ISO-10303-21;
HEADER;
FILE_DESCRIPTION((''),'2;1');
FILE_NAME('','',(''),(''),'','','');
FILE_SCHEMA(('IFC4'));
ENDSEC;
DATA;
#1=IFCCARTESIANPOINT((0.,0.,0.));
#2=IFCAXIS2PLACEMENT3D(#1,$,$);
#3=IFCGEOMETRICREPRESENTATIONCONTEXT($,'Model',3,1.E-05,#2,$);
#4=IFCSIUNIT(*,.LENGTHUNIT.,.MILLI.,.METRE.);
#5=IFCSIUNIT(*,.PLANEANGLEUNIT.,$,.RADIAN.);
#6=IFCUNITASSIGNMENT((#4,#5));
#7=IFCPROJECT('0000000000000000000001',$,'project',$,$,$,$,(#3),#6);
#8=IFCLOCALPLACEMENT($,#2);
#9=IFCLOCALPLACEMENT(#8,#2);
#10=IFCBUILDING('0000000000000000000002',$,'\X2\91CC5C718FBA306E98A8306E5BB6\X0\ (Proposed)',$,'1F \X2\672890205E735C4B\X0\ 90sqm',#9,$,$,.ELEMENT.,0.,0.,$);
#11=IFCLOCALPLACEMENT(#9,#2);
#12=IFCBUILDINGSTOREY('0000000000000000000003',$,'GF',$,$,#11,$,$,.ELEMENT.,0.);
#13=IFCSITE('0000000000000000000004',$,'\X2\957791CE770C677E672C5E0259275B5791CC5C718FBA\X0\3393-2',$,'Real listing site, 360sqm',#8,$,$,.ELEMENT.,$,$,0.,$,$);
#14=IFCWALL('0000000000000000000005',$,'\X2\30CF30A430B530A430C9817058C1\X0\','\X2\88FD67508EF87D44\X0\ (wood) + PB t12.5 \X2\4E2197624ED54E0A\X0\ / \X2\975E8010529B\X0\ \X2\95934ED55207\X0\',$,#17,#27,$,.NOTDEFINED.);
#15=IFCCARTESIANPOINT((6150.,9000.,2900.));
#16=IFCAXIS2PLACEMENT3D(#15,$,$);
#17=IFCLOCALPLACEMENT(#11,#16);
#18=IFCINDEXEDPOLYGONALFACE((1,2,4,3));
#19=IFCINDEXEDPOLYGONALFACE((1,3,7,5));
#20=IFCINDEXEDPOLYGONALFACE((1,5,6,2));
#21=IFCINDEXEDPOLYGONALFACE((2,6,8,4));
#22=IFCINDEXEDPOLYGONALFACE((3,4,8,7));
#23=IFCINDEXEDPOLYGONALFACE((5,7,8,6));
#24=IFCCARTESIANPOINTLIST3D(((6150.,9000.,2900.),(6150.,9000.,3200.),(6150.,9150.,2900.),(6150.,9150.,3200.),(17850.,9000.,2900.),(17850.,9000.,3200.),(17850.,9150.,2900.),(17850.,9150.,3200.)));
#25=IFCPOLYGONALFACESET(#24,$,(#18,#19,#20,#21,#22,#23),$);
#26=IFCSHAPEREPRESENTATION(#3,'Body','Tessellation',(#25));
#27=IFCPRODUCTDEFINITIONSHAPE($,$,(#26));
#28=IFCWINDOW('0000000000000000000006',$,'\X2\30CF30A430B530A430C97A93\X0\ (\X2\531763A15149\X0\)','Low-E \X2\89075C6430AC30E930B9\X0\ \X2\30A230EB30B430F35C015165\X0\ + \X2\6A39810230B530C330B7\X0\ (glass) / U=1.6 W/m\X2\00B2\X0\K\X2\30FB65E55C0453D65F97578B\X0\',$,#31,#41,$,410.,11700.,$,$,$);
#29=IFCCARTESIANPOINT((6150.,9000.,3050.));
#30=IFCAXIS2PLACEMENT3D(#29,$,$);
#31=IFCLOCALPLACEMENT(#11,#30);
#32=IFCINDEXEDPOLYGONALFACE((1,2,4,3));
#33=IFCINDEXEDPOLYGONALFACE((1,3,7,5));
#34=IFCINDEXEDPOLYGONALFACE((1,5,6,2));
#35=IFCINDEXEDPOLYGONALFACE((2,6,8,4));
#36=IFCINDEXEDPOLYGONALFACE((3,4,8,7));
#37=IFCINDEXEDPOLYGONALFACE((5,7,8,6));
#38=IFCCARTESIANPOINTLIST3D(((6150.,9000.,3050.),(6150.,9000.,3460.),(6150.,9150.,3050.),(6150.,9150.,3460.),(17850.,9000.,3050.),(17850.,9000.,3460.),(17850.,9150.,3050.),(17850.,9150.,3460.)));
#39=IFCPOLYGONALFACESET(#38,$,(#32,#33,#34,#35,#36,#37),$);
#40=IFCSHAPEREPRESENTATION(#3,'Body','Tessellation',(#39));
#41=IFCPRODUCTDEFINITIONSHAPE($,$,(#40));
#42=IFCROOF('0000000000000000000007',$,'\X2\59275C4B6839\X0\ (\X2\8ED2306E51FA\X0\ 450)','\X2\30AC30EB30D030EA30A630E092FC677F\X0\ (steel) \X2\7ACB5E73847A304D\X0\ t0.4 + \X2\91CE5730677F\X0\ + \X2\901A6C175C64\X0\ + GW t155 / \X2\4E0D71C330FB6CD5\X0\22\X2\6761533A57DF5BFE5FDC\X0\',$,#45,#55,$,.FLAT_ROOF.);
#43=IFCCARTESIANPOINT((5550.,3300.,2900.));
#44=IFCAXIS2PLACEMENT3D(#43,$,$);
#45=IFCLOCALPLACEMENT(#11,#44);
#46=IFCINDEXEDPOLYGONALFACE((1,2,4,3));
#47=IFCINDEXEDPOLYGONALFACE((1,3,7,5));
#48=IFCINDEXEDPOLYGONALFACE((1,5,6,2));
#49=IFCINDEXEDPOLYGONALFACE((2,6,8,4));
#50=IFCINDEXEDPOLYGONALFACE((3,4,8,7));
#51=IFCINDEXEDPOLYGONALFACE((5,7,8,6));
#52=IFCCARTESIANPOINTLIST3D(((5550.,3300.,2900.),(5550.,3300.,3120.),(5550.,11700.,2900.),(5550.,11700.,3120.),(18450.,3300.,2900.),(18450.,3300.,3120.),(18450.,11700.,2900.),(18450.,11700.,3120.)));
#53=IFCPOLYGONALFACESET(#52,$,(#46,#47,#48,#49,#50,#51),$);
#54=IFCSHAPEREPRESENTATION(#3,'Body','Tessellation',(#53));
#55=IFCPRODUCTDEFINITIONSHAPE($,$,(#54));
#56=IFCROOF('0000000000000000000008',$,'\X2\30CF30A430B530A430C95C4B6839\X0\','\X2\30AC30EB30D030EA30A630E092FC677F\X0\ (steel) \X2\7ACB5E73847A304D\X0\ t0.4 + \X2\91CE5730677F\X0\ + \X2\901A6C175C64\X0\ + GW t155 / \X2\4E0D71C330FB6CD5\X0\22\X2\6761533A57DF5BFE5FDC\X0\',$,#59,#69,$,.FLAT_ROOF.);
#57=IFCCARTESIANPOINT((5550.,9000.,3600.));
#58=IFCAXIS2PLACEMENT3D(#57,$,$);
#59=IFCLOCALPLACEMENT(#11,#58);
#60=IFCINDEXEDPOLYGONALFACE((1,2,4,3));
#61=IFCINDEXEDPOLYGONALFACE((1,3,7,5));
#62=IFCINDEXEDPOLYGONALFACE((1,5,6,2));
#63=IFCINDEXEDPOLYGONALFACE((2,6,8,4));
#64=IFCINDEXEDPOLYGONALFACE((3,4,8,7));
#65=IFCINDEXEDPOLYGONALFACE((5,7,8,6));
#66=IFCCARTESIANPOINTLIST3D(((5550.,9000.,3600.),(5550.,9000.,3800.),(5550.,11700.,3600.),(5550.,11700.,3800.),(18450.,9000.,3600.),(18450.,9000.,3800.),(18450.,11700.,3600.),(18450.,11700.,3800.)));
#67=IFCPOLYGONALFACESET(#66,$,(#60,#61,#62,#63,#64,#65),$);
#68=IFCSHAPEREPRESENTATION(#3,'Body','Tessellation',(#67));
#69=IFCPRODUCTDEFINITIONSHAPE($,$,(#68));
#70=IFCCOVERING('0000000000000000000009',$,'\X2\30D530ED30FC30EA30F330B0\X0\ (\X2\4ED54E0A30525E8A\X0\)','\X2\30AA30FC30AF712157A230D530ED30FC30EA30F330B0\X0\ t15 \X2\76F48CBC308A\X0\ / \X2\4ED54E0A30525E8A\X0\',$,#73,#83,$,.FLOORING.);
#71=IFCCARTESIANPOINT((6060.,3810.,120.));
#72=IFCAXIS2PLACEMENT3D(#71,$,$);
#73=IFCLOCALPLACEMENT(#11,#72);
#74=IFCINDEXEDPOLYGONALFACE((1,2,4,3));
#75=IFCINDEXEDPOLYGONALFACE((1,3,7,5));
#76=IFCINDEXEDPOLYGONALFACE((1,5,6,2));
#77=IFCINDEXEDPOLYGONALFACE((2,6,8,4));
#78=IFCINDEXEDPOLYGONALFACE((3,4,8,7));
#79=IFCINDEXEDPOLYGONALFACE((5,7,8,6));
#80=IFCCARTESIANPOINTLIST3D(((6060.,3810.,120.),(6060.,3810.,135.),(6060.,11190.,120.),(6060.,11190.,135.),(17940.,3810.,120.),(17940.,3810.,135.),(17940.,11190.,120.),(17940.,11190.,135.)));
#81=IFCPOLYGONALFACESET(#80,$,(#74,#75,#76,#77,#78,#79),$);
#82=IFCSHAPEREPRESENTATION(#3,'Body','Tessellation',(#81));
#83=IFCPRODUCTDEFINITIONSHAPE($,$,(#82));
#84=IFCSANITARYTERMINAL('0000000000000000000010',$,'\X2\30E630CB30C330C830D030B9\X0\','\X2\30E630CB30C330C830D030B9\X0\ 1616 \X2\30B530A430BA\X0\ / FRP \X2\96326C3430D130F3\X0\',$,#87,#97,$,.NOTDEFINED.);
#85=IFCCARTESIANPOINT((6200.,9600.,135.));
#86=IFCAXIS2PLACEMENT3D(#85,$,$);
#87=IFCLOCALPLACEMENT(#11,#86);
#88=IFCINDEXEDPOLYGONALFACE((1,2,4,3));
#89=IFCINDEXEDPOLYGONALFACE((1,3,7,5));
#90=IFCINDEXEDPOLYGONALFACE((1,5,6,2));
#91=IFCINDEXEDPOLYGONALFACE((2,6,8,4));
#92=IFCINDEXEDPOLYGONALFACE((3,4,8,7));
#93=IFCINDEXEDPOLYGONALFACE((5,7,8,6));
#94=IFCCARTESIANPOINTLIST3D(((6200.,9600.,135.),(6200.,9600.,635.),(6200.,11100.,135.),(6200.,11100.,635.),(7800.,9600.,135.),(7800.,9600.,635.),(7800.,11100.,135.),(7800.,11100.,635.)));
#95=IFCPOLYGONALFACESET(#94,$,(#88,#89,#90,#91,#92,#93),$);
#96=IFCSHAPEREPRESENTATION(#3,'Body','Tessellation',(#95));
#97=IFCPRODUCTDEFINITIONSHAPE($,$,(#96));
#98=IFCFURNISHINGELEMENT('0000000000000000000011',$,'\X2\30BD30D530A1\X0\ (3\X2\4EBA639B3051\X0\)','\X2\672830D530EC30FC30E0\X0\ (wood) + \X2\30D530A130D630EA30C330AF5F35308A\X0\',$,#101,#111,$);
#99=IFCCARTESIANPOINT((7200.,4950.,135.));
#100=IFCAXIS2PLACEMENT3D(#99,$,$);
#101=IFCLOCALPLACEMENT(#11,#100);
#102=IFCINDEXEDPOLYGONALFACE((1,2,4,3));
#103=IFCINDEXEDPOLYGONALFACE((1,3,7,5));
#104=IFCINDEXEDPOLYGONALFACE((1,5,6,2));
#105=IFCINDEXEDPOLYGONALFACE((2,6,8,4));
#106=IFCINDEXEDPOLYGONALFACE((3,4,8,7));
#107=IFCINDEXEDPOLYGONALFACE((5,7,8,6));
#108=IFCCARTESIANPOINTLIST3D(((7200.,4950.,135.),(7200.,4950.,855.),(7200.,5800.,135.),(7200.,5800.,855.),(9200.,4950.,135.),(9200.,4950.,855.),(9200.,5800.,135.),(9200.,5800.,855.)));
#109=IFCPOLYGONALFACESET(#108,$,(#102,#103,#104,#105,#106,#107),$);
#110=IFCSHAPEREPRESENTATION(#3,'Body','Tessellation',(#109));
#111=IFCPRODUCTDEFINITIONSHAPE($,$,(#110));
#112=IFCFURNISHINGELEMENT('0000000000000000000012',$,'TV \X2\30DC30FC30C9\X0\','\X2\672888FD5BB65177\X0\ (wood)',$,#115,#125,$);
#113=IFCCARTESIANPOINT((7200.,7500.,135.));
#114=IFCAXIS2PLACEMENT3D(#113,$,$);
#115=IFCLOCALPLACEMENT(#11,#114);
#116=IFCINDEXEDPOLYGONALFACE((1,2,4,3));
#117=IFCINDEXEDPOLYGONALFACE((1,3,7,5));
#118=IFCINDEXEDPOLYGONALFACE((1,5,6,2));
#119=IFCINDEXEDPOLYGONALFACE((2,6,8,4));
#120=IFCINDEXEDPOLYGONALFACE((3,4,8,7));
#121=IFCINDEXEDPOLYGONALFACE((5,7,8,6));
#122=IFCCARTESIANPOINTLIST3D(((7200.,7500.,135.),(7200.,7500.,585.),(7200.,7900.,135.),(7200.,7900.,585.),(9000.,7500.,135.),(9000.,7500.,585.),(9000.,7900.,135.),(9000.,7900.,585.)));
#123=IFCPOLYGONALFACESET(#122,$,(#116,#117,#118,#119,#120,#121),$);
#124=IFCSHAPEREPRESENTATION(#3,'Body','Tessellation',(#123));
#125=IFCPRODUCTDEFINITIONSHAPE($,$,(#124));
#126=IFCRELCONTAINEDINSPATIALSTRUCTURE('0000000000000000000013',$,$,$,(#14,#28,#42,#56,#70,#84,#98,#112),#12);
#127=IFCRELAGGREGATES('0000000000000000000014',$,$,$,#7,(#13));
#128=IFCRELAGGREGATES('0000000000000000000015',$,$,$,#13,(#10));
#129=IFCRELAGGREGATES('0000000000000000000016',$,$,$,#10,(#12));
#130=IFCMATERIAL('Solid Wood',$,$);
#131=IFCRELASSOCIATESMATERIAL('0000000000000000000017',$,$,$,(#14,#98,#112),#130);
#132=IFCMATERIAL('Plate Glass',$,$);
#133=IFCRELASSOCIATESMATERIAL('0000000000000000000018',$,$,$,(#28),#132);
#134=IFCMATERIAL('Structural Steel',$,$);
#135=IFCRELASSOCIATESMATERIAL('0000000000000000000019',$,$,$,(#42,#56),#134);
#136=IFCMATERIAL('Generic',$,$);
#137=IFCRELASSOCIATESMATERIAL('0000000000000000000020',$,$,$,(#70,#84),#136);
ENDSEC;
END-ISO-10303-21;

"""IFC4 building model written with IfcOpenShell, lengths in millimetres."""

from ifc_helpers import new_model, si_unit, frame, frame_2d, origin, place, context, project, spatial, rectangle, extrude, material, element, fill, save


model = new_model("IFC4")

# Units and contexts
model_context = context("Model", 3, precision=1e-05, world=origin())
ifc_project = project(units=[si_unit("LENGTHUNIT", "METRE", prefix="MILLI"), si_unit("PLANEANGLEUNIT", "RADIAN")], contexts=[model_context])

# Site, building, storey
site_placement = place(None, origin())
site = spatial("IfcSite", under=ifc_project, at=site_placement, Name="長野県松本市大字里山辺3393-2", ObjectType="Real listing site, 360sqm", CompositionType="ELEMENT", RefElevation=0.0)
building_placement = place(site_placement, origin())
building = spatial("IfcBuilding", under=site, at=building_placement, Name="里山辺の風の家 (Proposed)", ObjectType="1F 木造平屋 90sqm", CompositionType="ELEMENT", ElevationOfRefHeight=0.0, ElevationOfTerrain=0.0)
storey_placement = place(building_placement, origin())
storey = spatial("IfcBuildingStorey", under=building, at=storey_placement, Name="GF", CompositionType="ELEMENT", Elevation=0.0)

# Shared definitions
ifc_material_1 = material(Name="Solid Wood")

# Shared definitions
ifc_material_2 = material(Name="Plate Glass")

# Wall, opening, window
wall_1_placement = place(storey_placement, frame((6150.0, 9000.0, 2900.0)))
wall_1 = element("IfcWall", 1, at=wall_1_placement, inside=storey, material=ifc_material_1, Name="ハイサイド腰壁", Description="製材軸組 (wood) + PB t12.5 両面仕上 / 非耐力 間仕切", PredefinedType="NOTDEFINED", context=model_context, shape_type="SweptSolid", body=[
    extrude(rectangle(XDim=11700.0, YDim=150.0, at=frame_2d((5850.0, 75.0))), frame((6150.0, 9000.0, 2900.0)), (0.0, 0.0, 1.0), 700.0),
])
opening_1_placement = place(storey_placement, frame((6150.0, 9000.0, 3050.0)))
opening_1 = element("IfcOpeningElement", 2, at=opening_1_placement, cuts=wall_1, PredefinedType="NOTDEFINED", context=model_context, shape_type="SweptSolid", body=[
    extrude(rectangle(XDim=11700.0, YDim=150.0, at=frame_2d((5850.0, 75.0))), frame((6150.0, 9000.0, 3050.0)), (0.0, 0.0, 1.0), 410.0),
])
window_1_placement = place(storey_placement, frame((6150.0, 9000.0, 3050.0)))
window_1 = element("IfcWindow", 3, at=window_1_placement, inside=storey, material=ifc_material_2, Name="ハイサイド窓 (北採光)", Description="Low-E 複層ガラス アルゴン封入 + 樹脂サッシ (glass) / U=1.6 W/m²K・日射取得型", OverallHeight=410.0, OverallWidth=11700.0, context=model_context, shape_type="SweptSolid", body=[
    extrude(rectangle(XDim=11700.0, YDim=150.0, at=frame_2d((5850.0, 75.0))), frame((6150.0, 9000.0, 3050.0)), (0.0, 0.0, 1.0), 410.0),
])
fill(opening_1, window_1)

# Roofs
ifc_material_3 = material(Name="Structural Steel")
roof_1_placement = place(storey_placement, frame((5550.0, 3300.0, 2900.0)))
element("IfcRoof", 4, at=roof_1_placement, inside=storey, material=ifc_material_3, Name="大屋根 (軒の出 450)", Description="ガルバリウム鋼板 (steel) 立平葺き t0.4 + 野地板 + 通気層 + GW t155 / 不燃・法22条区域対応", PredefinedType="FLAT_ROOF", context=model_context, shape_type="SweptSolid", body=[
    extrude(rectangle(XDim=12900.0, YDim=8400.0, at=frame_2d((6450.0, 4200.0))), frame((5550.0, 3300.0, 2900.0)), (0.0, 0.0, 1.0), 220.0),
])
roof_2_placement = place(storey_placement, frame((5550.0, 9000.0, 3600.0)))
element("IfcRoof", 5, at=roof_2_placement, inside=storey, material=ifc_material_3, Name="ハイサイド屋根", Description="ガルバリウム鋼板 (steel) 立平葺き t0.4 + 野地板 + 通気層 + GW t155 / 不燃・法22条区域対応", PredefinedType="FLAT_ROOF", context=model_context, shape_type="SweptSolid", body=[
    extrude(rectangle(XDim=12900.0, YDim=2700.0, at=frame_2d((6450.0, 1350.0))), frame((5550.0, 9000.0, 3600.0)), (0.0, 0.0, 1.0), 200.0),
])

# Covering
ifc_material_4 = material(Name="Generic")
covering_placement = place(storey_placement, frame((6060.0, 3810.0, 120.0)))
element("IfcCovering", 6, at=covering_placement, inside=storey, material=ifc_material_4, Name="フローリング (仕上げ床)", Description="オーク無垢フローリング t15 直貼り / 仕上げ床", PredefinedType="FLOORING", context=model_context, shape_type="SweptSolid", body=[
    extrude(rectangle(XDim=11880.0, YDim=7380.0, at=frame_2d((5940.0, 3690.0))), frame((6060.0, 3810.0, 120.0)), (0.0, 0.0, 1.0), 15.0),
])

# Sanitary terminal
sanitary_terminal_placement = place(storey_placement, frame((6200.0, 9600.0, 135.0)))
element("IfcSanitaryTerminal", 7, at=sanitary_terminal_placement, inside=storey, material=ifc_material_4, Name="ユニットバス", Description="ユニットバス 1616 サイズ / FRP 防水パン", PredefinedType="NOTDEFINED", context=model_context, shape_type="SweptSolid", body=[
    extrude(rectangle(XDim=1600.0, YDim=1500.0, at=frame_2d((800.0, 750.0))), frame((6200.0, 9600.0, 135.0)), (0.0, 0.0, 1.0), 500.0),
])

# Furnishing elements
furnishing_1_placement = place(storey_placement, frame((7200.0, 4950.0, 135.0)))
element("IfcFurnishingElement", 8, at=furnishing_1_placement, inside=storey, material=ifc_material_1, Name="ソファ (3人掛け)", Description="木フレーム (wood) + ファブリック張り", context=model_context, shape_type="SweptSolid", body=[
    extrude(rectangle(XDim=2000.0, YDim=850.0, at=frame_2d((1000.0, 425.0))), frame((7200.0, 4950.0, 135.0)), (0.0, 0.0, 1.0), 720.0),
])
furnishing_2_placement = place(storey_placement, frame((7200.0, 7500.0, 135.0)))
element("IfcFurnishingElement", 9, at=furnishing_2_placement, inside=storey, material=ifc_material_1, Name="TV ボード", Description="木製家具 (wood)", context=model_context, shape_type="SweptSolid", body=[
    extrude(rectangle(XDim=1800.0, YDim=400.0, at=frame_2d((900.0, 200.0))), frame((7200.0, 7500.0, 135.0)), (0.0, 0.0, 1.0), 450.0),
])

save(model, "model.ifc")
